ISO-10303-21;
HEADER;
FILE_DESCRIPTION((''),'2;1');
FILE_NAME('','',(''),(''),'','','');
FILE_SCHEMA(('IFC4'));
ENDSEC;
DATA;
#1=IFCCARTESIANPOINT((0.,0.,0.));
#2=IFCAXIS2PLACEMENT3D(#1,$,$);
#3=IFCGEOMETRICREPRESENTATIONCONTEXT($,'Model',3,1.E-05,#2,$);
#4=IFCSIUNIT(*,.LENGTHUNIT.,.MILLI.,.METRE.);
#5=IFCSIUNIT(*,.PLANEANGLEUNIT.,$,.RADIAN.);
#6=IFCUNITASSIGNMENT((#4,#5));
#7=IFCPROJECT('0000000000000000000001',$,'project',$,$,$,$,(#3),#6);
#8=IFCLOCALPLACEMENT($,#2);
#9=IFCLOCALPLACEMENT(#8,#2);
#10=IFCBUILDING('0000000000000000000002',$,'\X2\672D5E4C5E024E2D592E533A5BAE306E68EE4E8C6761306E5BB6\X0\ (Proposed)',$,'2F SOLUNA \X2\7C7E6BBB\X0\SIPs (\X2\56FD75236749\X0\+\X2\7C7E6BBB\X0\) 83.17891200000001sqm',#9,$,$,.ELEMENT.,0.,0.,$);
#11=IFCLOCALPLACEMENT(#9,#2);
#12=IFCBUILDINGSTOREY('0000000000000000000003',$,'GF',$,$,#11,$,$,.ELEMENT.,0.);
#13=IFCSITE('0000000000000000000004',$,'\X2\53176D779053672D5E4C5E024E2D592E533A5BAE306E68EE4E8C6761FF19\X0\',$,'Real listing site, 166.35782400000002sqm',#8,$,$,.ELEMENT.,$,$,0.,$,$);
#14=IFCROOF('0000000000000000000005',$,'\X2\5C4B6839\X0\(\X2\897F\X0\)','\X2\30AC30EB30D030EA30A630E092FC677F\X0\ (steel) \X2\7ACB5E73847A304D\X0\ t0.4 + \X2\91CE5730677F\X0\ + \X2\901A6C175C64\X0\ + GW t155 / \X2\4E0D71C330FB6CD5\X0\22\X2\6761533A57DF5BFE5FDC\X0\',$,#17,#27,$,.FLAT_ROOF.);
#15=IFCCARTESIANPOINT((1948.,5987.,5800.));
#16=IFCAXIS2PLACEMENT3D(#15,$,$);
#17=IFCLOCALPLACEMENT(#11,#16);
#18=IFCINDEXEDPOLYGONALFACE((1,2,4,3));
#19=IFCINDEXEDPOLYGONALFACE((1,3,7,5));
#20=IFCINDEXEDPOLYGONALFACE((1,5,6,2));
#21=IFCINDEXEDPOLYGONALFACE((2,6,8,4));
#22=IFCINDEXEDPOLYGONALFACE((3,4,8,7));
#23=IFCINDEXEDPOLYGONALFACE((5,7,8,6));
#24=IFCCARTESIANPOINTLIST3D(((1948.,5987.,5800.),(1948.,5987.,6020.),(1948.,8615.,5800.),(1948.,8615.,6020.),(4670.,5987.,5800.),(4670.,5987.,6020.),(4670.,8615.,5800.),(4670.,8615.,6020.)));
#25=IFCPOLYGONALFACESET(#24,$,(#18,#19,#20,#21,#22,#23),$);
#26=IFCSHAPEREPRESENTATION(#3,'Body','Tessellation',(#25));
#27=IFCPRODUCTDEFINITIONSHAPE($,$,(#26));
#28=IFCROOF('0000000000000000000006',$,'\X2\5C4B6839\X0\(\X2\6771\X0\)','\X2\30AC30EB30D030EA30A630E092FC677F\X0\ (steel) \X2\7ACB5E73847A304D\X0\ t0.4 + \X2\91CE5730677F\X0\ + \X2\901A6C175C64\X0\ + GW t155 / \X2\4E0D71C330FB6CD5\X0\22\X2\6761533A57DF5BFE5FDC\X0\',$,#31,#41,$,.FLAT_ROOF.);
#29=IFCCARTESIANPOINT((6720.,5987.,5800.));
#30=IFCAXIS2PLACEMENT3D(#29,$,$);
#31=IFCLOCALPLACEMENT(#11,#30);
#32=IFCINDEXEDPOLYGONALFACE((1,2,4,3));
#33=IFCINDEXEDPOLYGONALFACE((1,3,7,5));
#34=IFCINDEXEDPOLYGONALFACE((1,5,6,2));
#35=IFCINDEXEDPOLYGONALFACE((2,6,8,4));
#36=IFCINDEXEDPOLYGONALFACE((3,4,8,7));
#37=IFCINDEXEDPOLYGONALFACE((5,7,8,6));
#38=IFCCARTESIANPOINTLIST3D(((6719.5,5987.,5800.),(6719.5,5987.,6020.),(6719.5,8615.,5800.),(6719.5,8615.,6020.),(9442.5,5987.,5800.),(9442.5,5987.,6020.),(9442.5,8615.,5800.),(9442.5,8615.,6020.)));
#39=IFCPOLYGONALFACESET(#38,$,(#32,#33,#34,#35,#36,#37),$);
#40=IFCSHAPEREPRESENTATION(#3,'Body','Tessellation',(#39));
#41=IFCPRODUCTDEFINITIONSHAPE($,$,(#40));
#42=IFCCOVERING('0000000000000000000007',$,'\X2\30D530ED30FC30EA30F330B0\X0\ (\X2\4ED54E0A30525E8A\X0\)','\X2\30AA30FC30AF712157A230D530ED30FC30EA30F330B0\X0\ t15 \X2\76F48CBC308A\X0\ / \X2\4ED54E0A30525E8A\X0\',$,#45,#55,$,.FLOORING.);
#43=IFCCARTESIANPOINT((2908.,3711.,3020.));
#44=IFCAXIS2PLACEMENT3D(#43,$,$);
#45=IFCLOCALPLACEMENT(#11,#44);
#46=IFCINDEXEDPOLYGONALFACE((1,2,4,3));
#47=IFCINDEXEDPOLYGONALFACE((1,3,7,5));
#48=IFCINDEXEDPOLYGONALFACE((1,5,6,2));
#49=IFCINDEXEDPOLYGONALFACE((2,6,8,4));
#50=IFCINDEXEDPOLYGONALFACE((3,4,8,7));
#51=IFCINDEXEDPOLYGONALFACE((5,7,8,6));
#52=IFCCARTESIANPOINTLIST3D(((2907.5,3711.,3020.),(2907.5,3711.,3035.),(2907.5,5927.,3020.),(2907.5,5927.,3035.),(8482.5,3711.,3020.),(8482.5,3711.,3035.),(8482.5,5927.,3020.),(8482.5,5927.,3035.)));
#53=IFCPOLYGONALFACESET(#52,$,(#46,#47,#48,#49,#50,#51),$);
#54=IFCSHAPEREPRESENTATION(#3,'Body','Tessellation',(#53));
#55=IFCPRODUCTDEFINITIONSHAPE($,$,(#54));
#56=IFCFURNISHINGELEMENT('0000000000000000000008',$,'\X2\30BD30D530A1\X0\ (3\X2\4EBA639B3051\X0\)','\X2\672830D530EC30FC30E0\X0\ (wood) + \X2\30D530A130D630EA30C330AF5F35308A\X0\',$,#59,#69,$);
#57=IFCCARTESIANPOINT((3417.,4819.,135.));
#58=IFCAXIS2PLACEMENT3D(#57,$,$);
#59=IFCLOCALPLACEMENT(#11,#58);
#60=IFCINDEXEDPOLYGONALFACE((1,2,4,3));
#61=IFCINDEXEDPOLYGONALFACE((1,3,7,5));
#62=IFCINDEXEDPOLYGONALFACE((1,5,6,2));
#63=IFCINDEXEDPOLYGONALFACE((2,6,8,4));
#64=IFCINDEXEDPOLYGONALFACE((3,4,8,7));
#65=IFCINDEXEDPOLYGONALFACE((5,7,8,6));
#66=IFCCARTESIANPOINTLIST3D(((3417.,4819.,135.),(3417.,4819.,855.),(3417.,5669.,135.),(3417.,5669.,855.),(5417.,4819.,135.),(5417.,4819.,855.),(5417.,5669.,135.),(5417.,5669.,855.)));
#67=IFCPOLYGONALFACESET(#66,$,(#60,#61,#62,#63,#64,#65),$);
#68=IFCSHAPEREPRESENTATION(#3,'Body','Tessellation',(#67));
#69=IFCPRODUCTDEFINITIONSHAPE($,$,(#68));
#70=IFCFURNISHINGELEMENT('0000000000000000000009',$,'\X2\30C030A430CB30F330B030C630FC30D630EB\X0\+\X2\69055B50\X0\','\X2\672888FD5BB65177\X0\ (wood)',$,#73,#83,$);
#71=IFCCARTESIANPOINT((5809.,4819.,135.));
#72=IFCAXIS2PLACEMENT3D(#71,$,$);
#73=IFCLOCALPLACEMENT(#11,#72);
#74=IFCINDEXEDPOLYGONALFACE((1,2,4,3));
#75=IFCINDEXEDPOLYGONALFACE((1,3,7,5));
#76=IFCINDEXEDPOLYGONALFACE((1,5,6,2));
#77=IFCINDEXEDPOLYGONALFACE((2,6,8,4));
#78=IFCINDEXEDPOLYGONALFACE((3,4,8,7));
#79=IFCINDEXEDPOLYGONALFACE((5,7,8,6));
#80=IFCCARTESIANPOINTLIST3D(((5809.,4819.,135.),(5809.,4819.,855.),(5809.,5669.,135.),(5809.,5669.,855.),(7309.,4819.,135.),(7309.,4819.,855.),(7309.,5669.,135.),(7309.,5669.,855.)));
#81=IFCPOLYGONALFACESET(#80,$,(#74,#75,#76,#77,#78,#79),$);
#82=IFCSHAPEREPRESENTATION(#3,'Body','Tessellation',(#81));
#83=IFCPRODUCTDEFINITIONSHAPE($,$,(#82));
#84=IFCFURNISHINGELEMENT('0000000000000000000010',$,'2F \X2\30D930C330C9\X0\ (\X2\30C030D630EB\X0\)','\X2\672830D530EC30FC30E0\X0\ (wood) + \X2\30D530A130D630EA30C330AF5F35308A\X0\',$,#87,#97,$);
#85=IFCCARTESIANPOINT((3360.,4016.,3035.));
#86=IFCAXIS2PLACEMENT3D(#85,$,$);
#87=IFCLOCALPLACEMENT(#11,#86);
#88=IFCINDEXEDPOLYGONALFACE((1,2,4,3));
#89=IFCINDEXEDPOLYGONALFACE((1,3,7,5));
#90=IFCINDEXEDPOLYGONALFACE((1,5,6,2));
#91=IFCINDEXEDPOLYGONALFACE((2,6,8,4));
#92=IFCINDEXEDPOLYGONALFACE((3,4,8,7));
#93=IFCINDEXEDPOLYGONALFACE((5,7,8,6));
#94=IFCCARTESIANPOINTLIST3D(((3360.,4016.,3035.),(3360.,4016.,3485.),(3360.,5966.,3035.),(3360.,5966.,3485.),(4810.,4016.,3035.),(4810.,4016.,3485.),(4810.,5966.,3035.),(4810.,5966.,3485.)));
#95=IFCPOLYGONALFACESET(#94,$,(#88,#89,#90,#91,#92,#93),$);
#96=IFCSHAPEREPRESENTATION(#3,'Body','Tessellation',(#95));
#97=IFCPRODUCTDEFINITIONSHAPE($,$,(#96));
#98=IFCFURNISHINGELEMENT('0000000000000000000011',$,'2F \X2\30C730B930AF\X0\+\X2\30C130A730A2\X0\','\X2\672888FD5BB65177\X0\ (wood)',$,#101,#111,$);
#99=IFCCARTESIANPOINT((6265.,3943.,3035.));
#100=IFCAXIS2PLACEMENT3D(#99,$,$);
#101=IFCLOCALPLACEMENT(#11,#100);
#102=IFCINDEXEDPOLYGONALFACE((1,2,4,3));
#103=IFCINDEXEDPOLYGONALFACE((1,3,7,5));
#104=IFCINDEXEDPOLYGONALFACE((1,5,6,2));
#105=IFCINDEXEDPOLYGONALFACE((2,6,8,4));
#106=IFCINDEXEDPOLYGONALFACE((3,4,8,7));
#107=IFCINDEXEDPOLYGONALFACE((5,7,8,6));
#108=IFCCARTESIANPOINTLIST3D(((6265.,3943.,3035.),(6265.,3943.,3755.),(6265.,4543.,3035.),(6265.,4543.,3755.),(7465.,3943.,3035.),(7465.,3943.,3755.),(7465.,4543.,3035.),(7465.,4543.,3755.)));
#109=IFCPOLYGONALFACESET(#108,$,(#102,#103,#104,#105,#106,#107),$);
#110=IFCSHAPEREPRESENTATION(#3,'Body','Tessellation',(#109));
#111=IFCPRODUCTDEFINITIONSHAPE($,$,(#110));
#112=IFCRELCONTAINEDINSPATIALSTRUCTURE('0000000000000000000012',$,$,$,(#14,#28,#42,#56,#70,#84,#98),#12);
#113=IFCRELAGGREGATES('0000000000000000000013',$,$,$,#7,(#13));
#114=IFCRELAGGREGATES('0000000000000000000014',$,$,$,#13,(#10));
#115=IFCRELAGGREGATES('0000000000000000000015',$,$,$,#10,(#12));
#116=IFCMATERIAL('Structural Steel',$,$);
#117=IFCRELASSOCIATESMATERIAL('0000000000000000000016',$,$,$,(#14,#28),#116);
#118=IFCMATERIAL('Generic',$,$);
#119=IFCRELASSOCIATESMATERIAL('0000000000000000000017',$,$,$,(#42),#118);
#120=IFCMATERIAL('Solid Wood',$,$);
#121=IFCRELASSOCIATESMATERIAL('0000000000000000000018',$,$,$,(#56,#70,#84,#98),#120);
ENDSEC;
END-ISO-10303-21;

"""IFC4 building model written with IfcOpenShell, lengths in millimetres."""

from ifc_helpers import new_model, si_unit, frame, frame_2d, origin, place, context, project, spatial, rectangle, extrude, material, element, save


model = new_model("IFC4")

# Units and contexts
model_context = context("Model", 3, precision=1e-05, world=origin())
ifc_project = project(units=[si_unit("LENGTHUNIT", "METRE", prefix="MILLI"), si_unit("PLANEANGLEUNIT", "RADIAN")], contexts=[model_context])

# Site, building, storey
site_placement = place(None, origin())
site = spatial("IfcSite", under=ifc_project, at=site_placement, Name="北海道札幌市中央区宮の森二条９", ObjectType="Real listing site, 166.35782400000002sqm", CompositionType="ELEMENT", RefElevation=0.0)
building_placement = place(site_placement, origin())
building = spatial("IfcBuilding", under=site, at=building_placement, Name="札幌市中央区宮の森二条の家 (Proposed)", ObjectType="2F SOLUNA 籾殻SIPs (国産杉+籾殻) 83.17891200000001sqm", CompositionType="ELEMENT", ElevationOfRefHeight=0.0, ElevationOfTerrain=0.0)
storey_placement = place(building_placement, origin())
storey = spatial("IfcBuildingStorey", under=building, at=storey_placement, Name="GF", CompositionType="ELEMENT", Elevation=0.0)

# Shared definitions
ifc_material_1 = material(Name="Solid Wood")

# Roofs
ifc_material_2 = material(Name="Structural Steel")
roof_1_placement = place(storey_placement, frame((1948.0, 5987.0, 5800.0)))
element("IfcRoof", 1, at=roof_1_placement, inside=storey, material=ifc_material_2, Name="屋根(西)", Description="ガルバリウム鋼板 (steel) 立平葺き t0.4 + 野地板 + 通気層 + GW t155 / 不燃・法22条区域対応", PredefinedType="FLAT_ROOF", context=model_context, shape_type="SweptSolid", body=[
    extrude(rectangle(XDim=2722.0, YDim=2628.0, at=frame_2d((1361.0, 1314.0))), frame((1948.0, 5987.0, 5800.0)), (0.0, 0.0, 1.0), 220.0),
])
roof_2_placement = place(storey_placement, frame((6720.0, 5987.0, 5800.0)))
element("IfcRoof", 2, at=roof_2_placement, inside=storey, material=ifc_material_2, Name="屋根(東)", Description="ガルバリウム鋼板 (steel) 立平葺き t0.4 + 野地板 + 通気層 + GW t155 / 不燃・法22条区域対応", PredefinedType="FLAT_ROOF", context=model_context, shape_type="SweptSolid", body=[
    extrude(rectangle(XDim=2723.0, YDim=2628.0, at=frame_2d((1361.0, 1314.0))), frame((6720.0, 5987.0, 5800.0)), (0.0, 0.0, 1.0), 220.0),
])

# Covering
ifc_material_3 = material(Name="Generic")
covering_placement = place(storey_placement, frame((2908.0, 3711.0, 3020.0)))
element("IfcCovering", 3, at=covering_placement, inside=storey, material=ifc_material_3, Name="フローリング (仕上げ床)", Description="オーク無垢フローリング t15 直貼り / 仕上げ床", PredefinedType="FLOORING", context=model_context, shape_type="SweptSolid", body=[
    extrude(rectangle(XDim=5575.0, YDim=2216.0, at=frame_2d((2787.0, 1108.0))), frame((2908.0, 3711.0, 3020.0)), (0.0, 0.0, 1.0), 15.0),
])

# Furnishing elements
furnishing_1_placement = place(storey_placement, frame((3417.0, 4819.0, 135.0)))
element("IfcFurnishingElement", 4, at=furnishing_1_placement, inside=storey, material=ifc_material_1, Name="ソファ (3人掛け)", Description="木フレーム (wood) + ファブリック張り", context=model_context, shape_type="SweptSolid", body=[
    extrude(rectangle(XDim=2000.0, YDim=850.0, at=frame_2d((1000.0, 425.0))), frame((3417.0, 4819.0, 135.0)), (0.0, 0.0, 1.0), 720.0),
])
furnishing_2_placement = place(storey_placement, frame((5809.0, 4819.0, 135.0)))
element("IfcFurnishingElement", 5, at=furnishing_2_placement, inside=storey, material=ifc_material_1, Name="ダイニングテーブル+椅子", Description="木製家具 (wood)", context=model_context, shape_type="SweptSolid", body=[
    extrude(rectangle(XDim=1500.0, YDim=850.0, at=frame_2d((750.0, 425.0))), frame((5809.0, 4819.0, 135.0)), (0.0, 0.0, 1.0), 720.0),
])
furnishing_3_placement = place(storey_placement, frame((3360.0, 4016.0, 3035.0)))
element("IfcFurnishingElement", 6, at=furnishing_3_placement, inside=storey, material=ifc_material_1, Name="2F ベッド (ダブル)", Description="木フレーム (wood) + ファブリック張り", context=model_context, shape_type="SweptSolid", body=[
    extrude(rectangle(XDim=1450.0, YDim=1950.0, at=frame_2d((725.0, 975.0))), frame((3360.0, 4016.0, 3035.0)), (0.0, 0.0, 1.0), 450.0),
])
furnishing_4_placement = place(storey_placement, frame((6265.0, 3943.0, 3035.0)))
element("IfcFurnishingElement", 7, at=furnishing_4_placement, inside=storey, material=ifc_material_1, Name="2F デスク+チェア", Description="木製家具 (wood)", context=model_context, shape_type="SweptSolid", body=[
    extrude(rectangle(XDim=1200.0, YDim=600.0, at=frame_2d((600.0, 300.0))), frame((6265.0, 3943.0, 3035.0)), (0.0, 0.0, 1.0), 720.0),
])

save(model, "model.ifc")
